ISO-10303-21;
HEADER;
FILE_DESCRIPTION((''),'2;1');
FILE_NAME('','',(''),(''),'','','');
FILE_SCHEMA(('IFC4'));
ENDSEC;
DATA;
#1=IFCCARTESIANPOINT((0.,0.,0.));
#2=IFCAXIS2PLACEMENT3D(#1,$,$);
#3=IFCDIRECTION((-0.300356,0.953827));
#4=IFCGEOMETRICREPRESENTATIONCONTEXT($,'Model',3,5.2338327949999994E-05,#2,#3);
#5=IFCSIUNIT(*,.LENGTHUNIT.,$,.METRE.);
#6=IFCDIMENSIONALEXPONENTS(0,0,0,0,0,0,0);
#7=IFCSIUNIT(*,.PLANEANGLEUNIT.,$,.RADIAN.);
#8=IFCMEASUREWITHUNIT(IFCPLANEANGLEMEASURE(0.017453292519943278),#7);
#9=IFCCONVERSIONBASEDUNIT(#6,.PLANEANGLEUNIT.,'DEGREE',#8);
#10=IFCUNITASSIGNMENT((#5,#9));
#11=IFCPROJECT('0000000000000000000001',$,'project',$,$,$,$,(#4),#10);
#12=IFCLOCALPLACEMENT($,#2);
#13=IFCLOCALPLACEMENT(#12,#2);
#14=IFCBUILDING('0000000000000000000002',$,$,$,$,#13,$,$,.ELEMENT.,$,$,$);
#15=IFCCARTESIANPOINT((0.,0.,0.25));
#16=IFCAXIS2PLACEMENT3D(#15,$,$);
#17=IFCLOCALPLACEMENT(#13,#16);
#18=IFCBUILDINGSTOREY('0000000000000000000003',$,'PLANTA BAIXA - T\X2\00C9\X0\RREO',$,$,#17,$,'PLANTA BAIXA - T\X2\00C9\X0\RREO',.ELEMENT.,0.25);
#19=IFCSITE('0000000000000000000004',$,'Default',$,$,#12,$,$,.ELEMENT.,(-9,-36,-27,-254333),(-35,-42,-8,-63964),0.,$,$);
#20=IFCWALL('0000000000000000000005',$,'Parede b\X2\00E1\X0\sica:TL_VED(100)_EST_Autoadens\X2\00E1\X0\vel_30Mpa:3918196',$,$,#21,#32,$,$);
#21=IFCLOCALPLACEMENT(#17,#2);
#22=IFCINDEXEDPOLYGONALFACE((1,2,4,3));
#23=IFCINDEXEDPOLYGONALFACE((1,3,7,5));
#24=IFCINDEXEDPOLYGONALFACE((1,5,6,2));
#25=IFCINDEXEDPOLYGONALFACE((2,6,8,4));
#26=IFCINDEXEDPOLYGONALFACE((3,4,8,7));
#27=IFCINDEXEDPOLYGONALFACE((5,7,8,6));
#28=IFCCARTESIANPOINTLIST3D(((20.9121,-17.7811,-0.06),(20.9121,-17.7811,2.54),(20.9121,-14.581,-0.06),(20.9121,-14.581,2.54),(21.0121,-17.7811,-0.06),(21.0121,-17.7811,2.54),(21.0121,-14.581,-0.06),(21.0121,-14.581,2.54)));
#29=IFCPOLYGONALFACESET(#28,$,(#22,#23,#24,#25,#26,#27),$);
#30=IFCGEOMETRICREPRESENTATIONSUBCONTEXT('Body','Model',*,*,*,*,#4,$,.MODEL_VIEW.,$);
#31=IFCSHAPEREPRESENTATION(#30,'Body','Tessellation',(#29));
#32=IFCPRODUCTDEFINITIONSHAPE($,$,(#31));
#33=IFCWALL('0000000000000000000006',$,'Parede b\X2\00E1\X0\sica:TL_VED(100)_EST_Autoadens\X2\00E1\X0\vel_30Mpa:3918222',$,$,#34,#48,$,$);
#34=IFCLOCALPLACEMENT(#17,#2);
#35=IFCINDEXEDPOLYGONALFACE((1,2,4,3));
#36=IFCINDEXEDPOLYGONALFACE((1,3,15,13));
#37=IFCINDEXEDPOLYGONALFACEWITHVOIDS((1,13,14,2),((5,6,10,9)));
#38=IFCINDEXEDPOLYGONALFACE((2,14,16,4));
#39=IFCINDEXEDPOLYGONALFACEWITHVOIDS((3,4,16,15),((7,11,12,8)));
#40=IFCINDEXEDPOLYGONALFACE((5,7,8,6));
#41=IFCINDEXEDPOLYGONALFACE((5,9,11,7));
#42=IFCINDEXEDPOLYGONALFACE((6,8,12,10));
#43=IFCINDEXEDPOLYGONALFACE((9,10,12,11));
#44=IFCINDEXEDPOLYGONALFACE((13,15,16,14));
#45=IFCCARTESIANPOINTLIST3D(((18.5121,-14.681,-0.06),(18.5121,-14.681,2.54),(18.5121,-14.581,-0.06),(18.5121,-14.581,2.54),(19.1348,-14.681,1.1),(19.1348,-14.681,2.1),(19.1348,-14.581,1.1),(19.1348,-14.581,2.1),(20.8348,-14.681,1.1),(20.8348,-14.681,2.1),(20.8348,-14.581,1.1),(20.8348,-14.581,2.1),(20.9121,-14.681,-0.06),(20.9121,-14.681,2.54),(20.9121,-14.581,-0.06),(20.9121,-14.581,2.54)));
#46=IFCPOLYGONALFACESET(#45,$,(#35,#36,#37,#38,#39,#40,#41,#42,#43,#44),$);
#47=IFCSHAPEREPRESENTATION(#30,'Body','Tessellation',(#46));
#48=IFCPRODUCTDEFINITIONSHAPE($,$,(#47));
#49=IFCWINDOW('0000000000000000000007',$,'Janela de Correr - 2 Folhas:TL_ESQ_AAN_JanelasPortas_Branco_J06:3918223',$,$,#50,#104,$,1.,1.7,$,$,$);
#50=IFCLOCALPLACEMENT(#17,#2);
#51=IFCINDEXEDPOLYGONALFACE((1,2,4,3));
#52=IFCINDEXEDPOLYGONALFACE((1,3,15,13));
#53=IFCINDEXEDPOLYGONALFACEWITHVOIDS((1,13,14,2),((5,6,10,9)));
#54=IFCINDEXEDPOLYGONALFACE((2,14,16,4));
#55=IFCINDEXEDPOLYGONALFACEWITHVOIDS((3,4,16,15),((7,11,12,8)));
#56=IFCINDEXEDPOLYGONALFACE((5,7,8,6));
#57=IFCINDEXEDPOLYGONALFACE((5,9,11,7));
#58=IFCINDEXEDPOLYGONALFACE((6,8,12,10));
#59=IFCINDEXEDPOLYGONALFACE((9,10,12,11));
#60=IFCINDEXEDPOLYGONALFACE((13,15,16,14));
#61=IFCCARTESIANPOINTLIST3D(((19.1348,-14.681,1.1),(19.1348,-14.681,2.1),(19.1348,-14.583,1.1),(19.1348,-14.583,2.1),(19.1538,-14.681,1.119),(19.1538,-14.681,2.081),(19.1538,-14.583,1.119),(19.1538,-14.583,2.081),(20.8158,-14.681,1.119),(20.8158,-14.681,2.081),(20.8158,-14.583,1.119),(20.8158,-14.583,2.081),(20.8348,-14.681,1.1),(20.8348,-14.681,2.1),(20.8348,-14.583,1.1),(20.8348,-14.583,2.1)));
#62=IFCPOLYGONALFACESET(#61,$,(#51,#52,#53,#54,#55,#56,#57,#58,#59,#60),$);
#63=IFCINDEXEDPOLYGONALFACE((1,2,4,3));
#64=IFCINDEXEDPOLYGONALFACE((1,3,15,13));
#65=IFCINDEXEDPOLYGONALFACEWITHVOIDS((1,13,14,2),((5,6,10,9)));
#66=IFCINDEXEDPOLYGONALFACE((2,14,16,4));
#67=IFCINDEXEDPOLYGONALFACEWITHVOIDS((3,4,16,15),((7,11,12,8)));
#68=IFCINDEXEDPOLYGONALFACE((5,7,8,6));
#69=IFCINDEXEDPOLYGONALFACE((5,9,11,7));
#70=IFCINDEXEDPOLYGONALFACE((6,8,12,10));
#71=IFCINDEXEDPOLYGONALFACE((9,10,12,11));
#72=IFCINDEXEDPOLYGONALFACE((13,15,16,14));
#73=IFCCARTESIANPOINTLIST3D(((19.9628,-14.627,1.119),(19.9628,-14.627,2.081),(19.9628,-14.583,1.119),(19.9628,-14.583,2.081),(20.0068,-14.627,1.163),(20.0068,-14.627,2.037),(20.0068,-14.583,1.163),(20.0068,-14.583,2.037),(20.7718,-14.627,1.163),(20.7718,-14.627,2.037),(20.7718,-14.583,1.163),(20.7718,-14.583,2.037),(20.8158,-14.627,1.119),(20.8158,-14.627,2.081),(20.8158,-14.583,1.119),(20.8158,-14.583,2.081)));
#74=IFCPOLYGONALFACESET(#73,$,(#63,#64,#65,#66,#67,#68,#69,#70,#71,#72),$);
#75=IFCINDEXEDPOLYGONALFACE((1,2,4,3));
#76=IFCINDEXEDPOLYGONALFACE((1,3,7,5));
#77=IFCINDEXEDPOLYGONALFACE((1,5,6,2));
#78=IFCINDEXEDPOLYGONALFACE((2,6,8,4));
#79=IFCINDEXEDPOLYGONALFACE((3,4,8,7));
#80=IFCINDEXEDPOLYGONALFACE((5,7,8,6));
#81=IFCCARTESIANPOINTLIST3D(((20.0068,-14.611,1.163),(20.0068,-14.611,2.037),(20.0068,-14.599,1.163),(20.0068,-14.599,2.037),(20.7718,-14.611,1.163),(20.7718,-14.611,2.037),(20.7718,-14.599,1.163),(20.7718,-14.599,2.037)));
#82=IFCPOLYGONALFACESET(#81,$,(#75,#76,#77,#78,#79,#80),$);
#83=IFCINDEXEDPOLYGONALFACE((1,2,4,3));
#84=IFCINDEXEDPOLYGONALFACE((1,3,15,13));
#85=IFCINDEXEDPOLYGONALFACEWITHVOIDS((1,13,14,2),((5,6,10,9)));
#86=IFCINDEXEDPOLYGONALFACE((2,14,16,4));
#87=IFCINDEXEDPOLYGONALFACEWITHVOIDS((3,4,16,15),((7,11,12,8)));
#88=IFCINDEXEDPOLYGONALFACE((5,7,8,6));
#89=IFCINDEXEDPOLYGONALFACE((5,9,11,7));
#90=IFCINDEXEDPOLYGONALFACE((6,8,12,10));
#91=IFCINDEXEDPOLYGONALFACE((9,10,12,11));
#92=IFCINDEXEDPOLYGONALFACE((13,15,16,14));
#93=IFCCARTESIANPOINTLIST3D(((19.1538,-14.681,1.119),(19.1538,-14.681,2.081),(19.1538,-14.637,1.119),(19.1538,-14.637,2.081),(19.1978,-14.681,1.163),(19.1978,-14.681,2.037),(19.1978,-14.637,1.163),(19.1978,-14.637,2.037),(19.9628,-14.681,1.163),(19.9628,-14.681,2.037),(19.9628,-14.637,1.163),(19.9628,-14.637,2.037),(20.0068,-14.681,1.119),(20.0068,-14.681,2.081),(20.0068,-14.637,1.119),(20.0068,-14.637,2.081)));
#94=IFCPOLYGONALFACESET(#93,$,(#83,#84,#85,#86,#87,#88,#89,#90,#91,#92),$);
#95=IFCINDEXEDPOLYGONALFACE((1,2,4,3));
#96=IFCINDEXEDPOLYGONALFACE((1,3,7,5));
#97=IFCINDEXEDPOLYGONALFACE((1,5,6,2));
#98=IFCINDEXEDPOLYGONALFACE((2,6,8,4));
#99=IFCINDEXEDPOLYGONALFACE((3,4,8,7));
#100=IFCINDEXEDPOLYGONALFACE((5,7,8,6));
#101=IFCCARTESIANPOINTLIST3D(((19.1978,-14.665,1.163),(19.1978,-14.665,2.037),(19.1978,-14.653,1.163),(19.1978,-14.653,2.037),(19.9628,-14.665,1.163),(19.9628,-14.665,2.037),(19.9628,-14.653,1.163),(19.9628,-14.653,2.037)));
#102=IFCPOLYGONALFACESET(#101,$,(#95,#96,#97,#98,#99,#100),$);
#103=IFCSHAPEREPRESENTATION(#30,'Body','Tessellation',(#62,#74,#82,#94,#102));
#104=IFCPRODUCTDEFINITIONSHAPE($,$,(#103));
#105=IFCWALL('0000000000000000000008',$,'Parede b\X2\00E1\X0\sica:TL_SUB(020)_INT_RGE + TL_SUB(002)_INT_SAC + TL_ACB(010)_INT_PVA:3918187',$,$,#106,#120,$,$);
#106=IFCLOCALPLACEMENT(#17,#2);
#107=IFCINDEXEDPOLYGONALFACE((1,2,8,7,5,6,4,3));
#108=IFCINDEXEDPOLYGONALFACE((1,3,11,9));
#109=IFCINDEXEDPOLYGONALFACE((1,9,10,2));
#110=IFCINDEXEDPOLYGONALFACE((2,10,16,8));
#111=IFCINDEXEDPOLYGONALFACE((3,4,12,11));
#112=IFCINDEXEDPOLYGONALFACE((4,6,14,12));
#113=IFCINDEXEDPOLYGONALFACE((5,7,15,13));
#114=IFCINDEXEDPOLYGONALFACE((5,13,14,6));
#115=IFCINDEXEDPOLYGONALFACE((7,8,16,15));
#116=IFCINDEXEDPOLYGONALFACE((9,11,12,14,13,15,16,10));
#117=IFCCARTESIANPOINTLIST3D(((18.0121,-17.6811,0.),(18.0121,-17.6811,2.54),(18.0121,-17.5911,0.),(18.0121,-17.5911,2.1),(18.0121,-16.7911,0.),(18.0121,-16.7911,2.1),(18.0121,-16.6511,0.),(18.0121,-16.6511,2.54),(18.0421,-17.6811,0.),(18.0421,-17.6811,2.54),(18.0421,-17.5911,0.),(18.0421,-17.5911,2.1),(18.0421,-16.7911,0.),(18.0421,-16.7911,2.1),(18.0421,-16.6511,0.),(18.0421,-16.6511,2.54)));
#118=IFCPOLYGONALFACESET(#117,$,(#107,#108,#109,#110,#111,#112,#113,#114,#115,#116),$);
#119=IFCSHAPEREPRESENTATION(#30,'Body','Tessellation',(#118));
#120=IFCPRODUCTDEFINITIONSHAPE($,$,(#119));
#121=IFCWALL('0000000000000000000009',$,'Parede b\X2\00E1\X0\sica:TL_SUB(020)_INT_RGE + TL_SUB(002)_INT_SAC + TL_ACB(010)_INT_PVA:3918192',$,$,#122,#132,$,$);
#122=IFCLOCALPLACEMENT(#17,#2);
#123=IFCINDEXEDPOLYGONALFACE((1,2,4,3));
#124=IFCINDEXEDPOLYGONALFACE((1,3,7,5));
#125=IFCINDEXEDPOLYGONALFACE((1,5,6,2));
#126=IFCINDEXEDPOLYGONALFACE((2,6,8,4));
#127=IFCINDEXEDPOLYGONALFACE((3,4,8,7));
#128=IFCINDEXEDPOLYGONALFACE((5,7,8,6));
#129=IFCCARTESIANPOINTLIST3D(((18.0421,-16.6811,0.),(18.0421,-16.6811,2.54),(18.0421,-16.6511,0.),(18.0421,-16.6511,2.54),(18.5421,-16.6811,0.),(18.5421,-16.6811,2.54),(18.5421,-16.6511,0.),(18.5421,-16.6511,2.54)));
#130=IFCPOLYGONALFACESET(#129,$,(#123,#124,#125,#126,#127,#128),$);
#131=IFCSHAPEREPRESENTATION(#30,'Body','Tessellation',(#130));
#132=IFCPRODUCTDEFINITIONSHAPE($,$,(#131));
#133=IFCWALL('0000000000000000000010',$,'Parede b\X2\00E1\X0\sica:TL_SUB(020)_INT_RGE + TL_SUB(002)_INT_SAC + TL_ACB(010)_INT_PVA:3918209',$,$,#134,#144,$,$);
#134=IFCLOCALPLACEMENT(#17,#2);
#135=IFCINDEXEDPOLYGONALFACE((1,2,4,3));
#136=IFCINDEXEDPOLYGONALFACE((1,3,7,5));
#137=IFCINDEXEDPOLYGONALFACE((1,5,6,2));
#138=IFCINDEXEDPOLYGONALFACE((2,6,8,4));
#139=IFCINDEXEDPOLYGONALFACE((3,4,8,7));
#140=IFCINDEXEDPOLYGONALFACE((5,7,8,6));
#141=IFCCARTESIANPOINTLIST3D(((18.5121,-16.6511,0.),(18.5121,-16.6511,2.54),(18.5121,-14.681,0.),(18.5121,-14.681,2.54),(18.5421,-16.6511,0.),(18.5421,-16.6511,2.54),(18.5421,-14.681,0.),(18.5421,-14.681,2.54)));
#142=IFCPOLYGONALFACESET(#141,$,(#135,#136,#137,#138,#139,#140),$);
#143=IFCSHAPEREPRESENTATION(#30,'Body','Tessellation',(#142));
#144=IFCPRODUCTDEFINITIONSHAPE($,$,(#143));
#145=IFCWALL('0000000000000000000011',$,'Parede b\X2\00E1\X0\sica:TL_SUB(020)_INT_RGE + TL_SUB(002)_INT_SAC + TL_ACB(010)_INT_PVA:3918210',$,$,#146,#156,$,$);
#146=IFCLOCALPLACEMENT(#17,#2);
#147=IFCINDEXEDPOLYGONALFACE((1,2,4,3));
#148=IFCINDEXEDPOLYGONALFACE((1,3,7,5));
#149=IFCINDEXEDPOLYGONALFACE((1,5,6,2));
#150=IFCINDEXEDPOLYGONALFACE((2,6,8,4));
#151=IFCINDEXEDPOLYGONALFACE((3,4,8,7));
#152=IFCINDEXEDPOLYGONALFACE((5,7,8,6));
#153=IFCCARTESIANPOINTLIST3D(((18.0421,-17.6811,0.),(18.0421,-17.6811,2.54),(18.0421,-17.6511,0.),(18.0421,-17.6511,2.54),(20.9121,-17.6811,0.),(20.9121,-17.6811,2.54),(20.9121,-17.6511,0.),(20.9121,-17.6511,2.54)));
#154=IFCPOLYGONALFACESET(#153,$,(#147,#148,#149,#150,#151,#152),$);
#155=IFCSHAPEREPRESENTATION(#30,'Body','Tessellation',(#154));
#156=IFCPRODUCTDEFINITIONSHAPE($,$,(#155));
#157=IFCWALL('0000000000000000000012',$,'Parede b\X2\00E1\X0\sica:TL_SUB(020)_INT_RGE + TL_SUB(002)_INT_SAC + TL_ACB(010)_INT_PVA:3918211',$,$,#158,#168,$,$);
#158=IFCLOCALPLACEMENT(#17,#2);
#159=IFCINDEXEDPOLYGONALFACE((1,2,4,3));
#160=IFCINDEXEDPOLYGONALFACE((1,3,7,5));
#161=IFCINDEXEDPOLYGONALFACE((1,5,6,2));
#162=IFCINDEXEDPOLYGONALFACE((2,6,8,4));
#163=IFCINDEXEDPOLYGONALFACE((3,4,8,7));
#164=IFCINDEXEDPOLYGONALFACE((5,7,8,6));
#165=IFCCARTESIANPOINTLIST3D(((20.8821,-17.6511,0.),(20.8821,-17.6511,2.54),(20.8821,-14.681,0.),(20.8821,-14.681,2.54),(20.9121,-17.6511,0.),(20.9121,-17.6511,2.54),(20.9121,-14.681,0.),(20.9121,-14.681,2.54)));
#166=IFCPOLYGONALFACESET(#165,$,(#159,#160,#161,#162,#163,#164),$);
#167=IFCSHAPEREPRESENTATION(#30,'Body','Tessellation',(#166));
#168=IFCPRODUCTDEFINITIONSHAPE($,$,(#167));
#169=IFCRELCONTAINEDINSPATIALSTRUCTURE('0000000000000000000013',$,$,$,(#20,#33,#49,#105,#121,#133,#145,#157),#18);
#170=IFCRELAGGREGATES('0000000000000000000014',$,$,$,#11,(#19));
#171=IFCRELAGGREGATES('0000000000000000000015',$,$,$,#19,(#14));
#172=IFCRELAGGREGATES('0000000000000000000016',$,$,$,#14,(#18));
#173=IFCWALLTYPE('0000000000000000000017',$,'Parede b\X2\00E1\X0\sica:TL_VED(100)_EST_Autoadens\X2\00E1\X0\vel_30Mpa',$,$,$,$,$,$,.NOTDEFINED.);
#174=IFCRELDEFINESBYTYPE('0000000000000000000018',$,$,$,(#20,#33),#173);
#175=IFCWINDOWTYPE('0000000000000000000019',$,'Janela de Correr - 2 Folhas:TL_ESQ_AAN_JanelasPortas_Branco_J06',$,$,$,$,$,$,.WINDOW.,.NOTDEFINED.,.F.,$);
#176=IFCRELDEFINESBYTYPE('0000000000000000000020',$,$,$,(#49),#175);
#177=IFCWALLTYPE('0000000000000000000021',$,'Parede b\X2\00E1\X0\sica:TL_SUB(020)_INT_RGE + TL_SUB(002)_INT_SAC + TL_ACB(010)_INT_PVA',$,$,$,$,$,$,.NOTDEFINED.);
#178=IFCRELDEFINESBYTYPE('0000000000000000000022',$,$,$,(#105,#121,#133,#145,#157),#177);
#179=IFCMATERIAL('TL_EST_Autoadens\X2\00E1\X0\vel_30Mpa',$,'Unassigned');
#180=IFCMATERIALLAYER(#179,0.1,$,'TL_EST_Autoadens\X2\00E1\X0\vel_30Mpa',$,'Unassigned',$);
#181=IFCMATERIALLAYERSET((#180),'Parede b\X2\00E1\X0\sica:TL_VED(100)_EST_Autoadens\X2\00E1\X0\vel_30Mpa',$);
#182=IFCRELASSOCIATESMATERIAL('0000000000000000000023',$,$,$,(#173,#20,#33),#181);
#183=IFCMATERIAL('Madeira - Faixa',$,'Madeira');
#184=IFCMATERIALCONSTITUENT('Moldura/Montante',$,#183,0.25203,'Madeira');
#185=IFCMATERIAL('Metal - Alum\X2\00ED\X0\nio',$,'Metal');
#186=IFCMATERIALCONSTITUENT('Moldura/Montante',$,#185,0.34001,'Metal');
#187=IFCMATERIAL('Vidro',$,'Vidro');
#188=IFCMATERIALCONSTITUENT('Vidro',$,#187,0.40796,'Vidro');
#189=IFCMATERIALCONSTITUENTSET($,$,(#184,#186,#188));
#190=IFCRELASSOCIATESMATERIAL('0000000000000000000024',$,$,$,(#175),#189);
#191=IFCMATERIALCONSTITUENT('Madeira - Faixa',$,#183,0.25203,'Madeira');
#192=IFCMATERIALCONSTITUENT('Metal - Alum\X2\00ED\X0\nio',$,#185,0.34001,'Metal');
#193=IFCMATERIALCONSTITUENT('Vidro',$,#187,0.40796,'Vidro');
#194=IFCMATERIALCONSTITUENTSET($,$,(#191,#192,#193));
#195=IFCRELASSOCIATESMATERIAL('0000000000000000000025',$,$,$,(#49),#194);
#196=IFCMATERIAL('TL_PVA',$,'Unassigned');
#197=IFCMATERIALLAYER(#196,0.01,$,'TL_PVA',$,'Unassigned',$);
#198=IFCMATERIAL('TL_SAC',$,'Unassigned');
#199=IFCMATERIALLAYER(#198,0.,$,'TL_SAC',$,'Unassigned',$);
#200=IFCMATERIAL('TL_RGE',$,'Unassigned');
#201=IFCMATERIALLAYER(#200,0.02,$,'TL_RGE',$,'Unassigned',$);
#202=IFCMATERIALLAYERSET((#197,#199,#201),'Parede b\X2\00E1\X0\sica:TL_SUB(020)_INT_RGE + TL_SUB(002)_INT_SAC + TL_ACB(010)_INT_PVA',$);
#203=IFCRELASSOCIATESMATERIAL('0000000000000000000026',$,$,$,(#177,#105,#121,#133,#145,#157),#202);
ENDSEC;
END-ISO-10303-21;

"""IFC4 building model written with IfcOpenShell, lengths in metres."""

from ifc_helpers import new_model, entity, si_unit, converted_unit, direction, frame, frame_2d, origin, origin_2d_with_axis, place, context, subcontext, project, spatial, polyline, rectangle, outline, extrude, source, transform, mapped, material, layer, layer_set, layer_usage, constituent, constituent_set, type_object, type_shapes, element, fill, save


model = new_model("IFC4")

# Units and contexts
model_context = context("Model", 3, precision=5.2338327949999994e-05, world=origin(), true_north=direction((-0.300356, 0.953827)))
body_context = subcontext(model_context, "Body", "Model", "MODEL_VIEW")
ifc_project = project(units=[si_unit("LENGTHUNIT", "METRE"), converted_unit("PLANEANGLEUNIT", "DEGREE", entity("IfcPlaneAngleMeasure", 0.017453292519943278), si_unit("PLANEANGLEUNIT", "RADIAN"), dimensions=[0, 0, 0, 0, 0, 0, 0])], contexts=[model_context])

# Site, building, storey
site_placement = place(None, origin())
site = spatial("IfcSite", under=ifc_project, at=site_placement, Name="Default", CompositionType="ELEMENT", RefLatitude=(-9, -36, -27, -254333), RefLongitude=(-35, -42, -8, -63964), RefElevation=0.0)
building_placement = place(site_placement, origin())
building = spatial("IfcBuilding", under=site, at=building_placement, CompositionType="ELEMENT")
storey_placement = place(building_placement, frame((0.0, 0.0, 0.25)))
storey = spatial("IfcBuildingStorey", under=building, at=storey_placement, Name="PLANTA BAIXA - TÉRREO", LongName="PLANTA BAIXA - TÉRREO", CompositionType="ELEMENT", Elevation=0.25)

# Wall
ifc_material_1 = material(Name="TL_EST_Autoadensável_30Mpa", Category="Unassigned")
ifc_layer_1 = layer(ifc_material_1, 0.1, Name="TL_EST_Autoadensável_30Mpa", Category="Unassigned")
ifc_layer_set_1 = layer_set([ifc_layer_1], Name="Parede básica:TL_VED(100)_EST_Autoadensável_30Mpa")
ifc_layer_usage_1 = layer_usage(ifc_layer_set_1, "AXIS2", "POSITIVE", -0.05)
wall_type_1 = type_object("IfcWallType", Name="Parede básica:TL_VED(100)_EST_Autoadensável_30Mpa", PredefinedType="NOTDEFINED", material=ifc_layer_set_1)
wall_1_placement = place(storey_placement, frame((20.9621, -14.581, -0.06), z_axis=(0.0, 0.0, 1.0), x_axis=(0.0, -1.0, 0.0)))
element("IfcWall", 1, at=wall_1_placement, inside=storey, type_object=wall_type_1, material=ifc_layer_usage_1, Name="Parede básica:TL_VED(100)_EST_Autoadensável_30Mpa:3918196", context=body_context, shape_type="SweptSolid", body=[
    extrude(rectangle(XDim=3.2001, YDim=0.1, at=frame_2d((1.6001, 0.0), x_axis=(-1.0, 0.0))), origin(), (0.0, 0.0, 1.0), 2.6),
])

# Wall, opening, window
ifc_layer_usage_2 = layer_usage(ifc_layer_set_1, "AXIS2", "POSITIVE", -0.05)
wall_2_placement = place(storey_placement, frame((20.9121, -14.631, -0.06), z_axis=(0.0, 0.0, 1.0), x_axis=(-1.0, 0.0, 0.0)))
wall_2 = element("IfcWall", 2, at=wall_2_placement, inside=storey, type_object=wall_type_1, material=ifc_layer_usage_2, Name="Parede básica:TL_VED(100)_EST_Autoadensável_30Mpa:3918222", context=body_context, shape_type="SweptSolid", body=[
    extrude(rectangle(XDim=2.4, YDim=0.1, at=frame_2d((1.2, 0.0), x_axis=(-1.0, 0.0))), origin(), (0.0, 0.0, 1.0), 2.6),
])
opening_1_placement = place(wall_2_placement, frame((1.7774, 0.05, 1.16)))
opening_1 = element("IfcOpeningElement", 3, at=opening_1_placement, cuts=wall_2, PredefinedType="OPENING", context=body_context, shape_type="SweptSolid", body=[
    extrude(rectangle(XDim=1.0, YDim=1.7, at=frame_2d((0.5, 0.85), x_axis=(-1.0, 0.0))), frame((0.0, 0.0, 0.0), z_axis=(0.0, -1.0, 0.0), x_axis=(0.0, 0.0, 1.0)), (0.0, 0.0, 1.0), 0.1),
])
ifc_material_2 = material(Name="Madeira - Faixa", Category="Madeira")
ifc_constituent_1 = constituent(ifc_material_2, Name="Madeira - Faixa", Category="Madeira", fraction=0.25203)
ifc_material_3 = material(Name="Metal - Alumínio", Category="Metal")
ifc_constituent_2 = constituent(ifc_material_3, Name="Metal - Alumínio", Category="Metal", fraction=0.34001)
ifc_material_4 = material(Name="Vidro", Category="Vidro")
ifc_constituent_3 = constituent(ifc_material_4, Name="Vidro", Category="Vidro", fraction=0.40796)
ifc_constituent_set_1 = constituent_set(constituents=[ifc_constituent_1, ifc_constituent_2, ifc_constituent_3])
ifc_constituent_4 = constituent(ifc_material_2, Name="Moldura/Montante", Category="Madeira", fraction=0.25203)
ifc_constituent_5 = constituent(ifc_material_3, Name="Moldura/Montante", Category="Metal", fraction=0.34001)
ifc_constituent_6 = constituent(ifc_material_4, Name="Vidro", Category="Vidro", fraction=0.40796)
ifc_constituent_set_2 = constituent_set(constituents=[ifc_constituent_4, ifc_constituent_5, ifc_constituent_6])
window_type = type_object("IfcWindowType", Name="Janela de Correr - 2 Folhas:TL_ESQ_AAN_JanelasPortas_Branco_J06", ParameterTakesPrecedence=False, PartitioningType="NOTDEFINED", PredefinedType="WINDOW", material=ifc_constituent_set_2)
shared_shape_1 = source(origin(), body_context, "Body", "SweptSolid", [
    extrude(outline(polyline([(-0.85, -0.5), (0.85, -0.5), (0.85, 0.5), (-0.85, 0.5), (-0.85, -0.5)]), holes=[polyline([(-0.831, -0.481), (-0.831, 0.481), (0.831, 0.481), (0.831, -0.481), (-0.831, -0.481)])]), frame((0.85, 0.0, 0.5), z_axis=(0.0, 1.0, 0.0), x_axis=(1.0, 0.0, 0.0)), (0.0, 0.0, 1.0), 0.098),
    extrude(outline(polyline([(-0.4265, -0.481), (0.4265, -0.481), (0.4265, 0.481), (-0.4265, 0.481), (-0.4265, -0.481)]), holes=[polyline([(-0.3825, -0.437), (-0.3825, 0.437), (0.3825, 0.437), (0.3825, -0.437), (-0.3825, -0.437)])]), frame((1.2545, 0.054, 0.5), z_axis=(0.0, 1.0, 0.0), x_axis=(1.0, 0.0, 0.0)), (0.0, 0.0, 1.0), 0.044),
    extrude(rectangle(XDim=0.012, YDim=0.765, at=origin_2d_with_axis()), frame((1.2545, 0.076, 0.063), z_axis=(0.0, 0.0, 1.0), x_axis=(0.0, -1.0, 0.0)), (0.0, 0.0, 1.0), 0.874),
    extrude(outline(polyline([(-0.481, -0.4265), (0.481, -0.4265), (0.481, 0.4265), (-0.481, 0.4265), (-0.481, -0.4265)]), holes=[polyline([(-0.437, -0.3825), (-0.437, 0.3825), (0.437, 0.3825), (0.437, -0.3825), (-0.437, -0.3825)])]), frame((0.4455, 0.0, 0.5), z_axis=(0.0, 1.0, 0.0), x_axis=(0.0, 0.0, -1.0)), (0.0, 0.0, 1.0), 0.044),
    extrude(rectangle(XDim=0.012, YDim=0.765, at=origin_2d_with_axis()), frame((0.4455, 0.022, 0.063), z_axis=(0.0, 0.0, 1.0), x_axis=(0.0, -1.0, 0.0)), (0.0, 0.0, 1.0), 0.874),
])
type_shapes(window_type, [shared_shape_1])
window_placement = place(opening_1_placement, frame((0.0, 0.0, 0.0), z_axis=(0.0, 0.0, 1.0), x_axis=(-1.0, 0.0, 0.0)))
window = element("IfcWindow", 4, at=window_placement, inside=storey, type_object=window_type, material=ifc_constituent_set_1, Name="Janela de Correr - 2 Folhas:TL_ESQ_AAN_JanelasPortas_Branco_J06:3918223", OverallHeight=1.0, OverallWidth=1.7, context=body_context, shape_type="MappedRepresentation", body=[
    mapped(shared_shape_1, transform((0.0, 0.0, 0.0), scale=1.0)),
])
fill(opening_1, window)

# Wall, opening
ifc_material_5 = material(Name="TL_PVA", Category="Unassigned")
ifc_layer_2 = layer(ifc_material_5, 0.01, Name="TL_PVA", Category="Unassigned")
ifc_material_6 = material(Name="TL_SAC", Category="Unassigned")
ifc_layer_3 = layer(ifc_material_6, 0.0, Name="TL_SAC", Category="Unassigned")
ifc_material_7 = material(Name="TL_RGE", Category="Unassigned")
ifc_layer_4 = layer(ifc_material_7, 0.02, Name="TL_RGE", Category="Unassigned")
ifc_layer_set_2 = layer_set([ifc_layer_2, ifc_layer_3, ifc_layer_4], Name="Parede básica:TL_SUB(020)_INT_RGE + TL_SUB(002)_INT_SAC + TL_ACB(010)_INT_PVA")
ifc_layer_usage_3 = layer_usage(ifc_layer_set_2, "AXIS2", "NEGATIVE", 0.015)
wall_type_2 = type_object("IfcWallType", Name="Parede básica:TL_SUB(020)_INT_RGE + TL_SUB(002)_INT_SAC + TL_ACB(010)_INT_PVA", PredefinedType="NOTDEFINED", material=ifc_layer_set_2)
wall_3_placement = place(storey_placement, frame((18.0271, -16.6511, 0.0), z_axis=(0.0, 0.0, 1.0), x_axis=(0.0, -1.0, 0.0)))
wall_3 = element("IfcWall", 5, at=wall_3_placement, inside=storey, type_object=wall_type_2, material=ifc_layer_usage_3, Name="Parede básica:TL_SUB(020)_INT_RGE + TL_SUB(002)_INT_SAC + TL_ACB(010)_INT_PVA:3918187", context=body_context, shape_type="SweptSolid", body=[
    extrude(rectangle(XDim=1.03, YDim=0.03, at=frame_2d((0.515, 0.0), x_axis=(-1.0, 0.0))), origin(), (0.0, 0.0, 1.0), 2.54),
])
opening_2_placement = place(wall_3_placement, frame((-16.6511, -18.0271, 0.0)))
element("IfcOpeningElement", 6, at=opening_2_placement, cuts=wall_3, PredefinedType="OPENING", context=body_context, shape_type="SweptSolid", body=[
    extrude(rectangle(XDim=2.1, YDim=0.8, at=frame_2d((0.0, 0.0), x_axis=(0.0, 1.0))), frame((17.1911, 16.3881, 1.05), z_axis=(0.0, 1.0, 0.0), x_axis=(-1.0, 0.0, 0.0)), (0.0, 0.0, 1.0), 3.048),
])

# Walls
ifc_layer_usage_4 = layer_usage(ifc_layer_set_2, "AXIS2", "NEGATIVE", 0.015)
wall_4_placement = place(storey_placement, frame((18.5421, -16.6661, 0.0), z_axis=(0.0, 0.0, 1.0), x_axis=(-1.0, 0.0, 0.0)))
element("IfcWall", 7, at=wall_4_placement, inside=storey, type_object=wall_type_2, material=ifc_layer_usage_4, Name="Parede básica:TL_SUB(020)_INT_RGE + TL_SUB(002)_INT_SAC + TL_ACB(010)_INT_PVA:3918192", context=body_context, shape_type="SweptSolid", body=[
    extrude(rectangle(XDim=0.5, YDim=0.03, at=frame_2d((0.25, 0.0), x_axis=(-1.0, 0.0))), origin(), (0.0, 0.0, 1.0), 2.54),
])
ifc_layer_usage_5 = layer_usage(ifc_layer_set_2, "AXIS2", "POSITIVE", -0.015)
wall_5_placement = place(storey_placement, frame((18.5271, -16.6511, 0.0), z_axis=(0.0, 0.0, 1.0), x_axis=(0.0, 1.0, 0.0)))
element("IfcWall", 8, at=wall_5_placement, inside=storey, type_object=wall_type_2, material=ifc_layer_usage_5, Name="Parede básica:TL_SUB(020)_INT_RGE + TL_SUB(002)_INT_SAC + TL_ACB(010)_INT_PVA:3918209", context=body_context, shape_type="SweptSolid", body=[
    extrude(rectangle(XDim=1.9701, YDim=0.03, at=frame_2d((0.9851, 0.0), x_axis=(-1.0, 0.0))), origin(), (0.0, 0.0, 1.0), 2.54),
])
ifc_layer_usage_6 = layer_usage(ifc_layer_set_2, "AXIS2", "POSITIVE", -0.015)
wall_6_placement = place(storey_placement, frame((20.9121, -17.6661, 0.0), z_axis=(0.0, 0.0, 1.0), x_axis=(-1.0, 0.0, 0.0)))
element("IfcWall", 9, at=wall_6_placement, inside=storey, type_object=wall_type_2, material=ifc_layer_usage_6, Name="Parede básica:TL_SUB(020)_INT_RGE + TL_SUB(002)_INT_SAC + TL_ACB(010)_INT_PVA:3918210", context=body_context, shape_type="SweptSolid", body=[
    extrude(rectangle(XDim=2.87, YDim=0.03, at=frame_2d((1.435, 0.0), x_axis=(-1.0, 0.0))), origin(), (0.0, 0.0, 1.0), 2.54),
])
ifc_layer_usage_7 = layer_usage(ifc_layer_set_2, "AXIS2", "POSITIVE", -0.015)
wall_7_placement = place(storey_placement, frame((20.8971, -14.681, 0.0), z_axis=(0.0, 0.0, 1.0), x_axis=(0.0, -1.0, 0.0)))
element("IfcWall", 10, at=wall_7_placement, inside=storey, type_object=wall_type_2, material=ifc_layer_usage_7, Name="Parede básica:TL_SUB(020)_INT_RGE + TL_SUB(002)_INT_SAC + TL_ACB(010)_INT_PVA:3918211", context=body_context, shape_type="SweptSolid", body=[
    extrude(rectangle(XDim=2.9701, YDim=0.03, at=frame_2d((1.4851, 0.0), x_axis=(-1.0, 0.0))), origin(), (0.0, 0.0, 1.0), 2.54),
])

save(model, "model.ifc")
